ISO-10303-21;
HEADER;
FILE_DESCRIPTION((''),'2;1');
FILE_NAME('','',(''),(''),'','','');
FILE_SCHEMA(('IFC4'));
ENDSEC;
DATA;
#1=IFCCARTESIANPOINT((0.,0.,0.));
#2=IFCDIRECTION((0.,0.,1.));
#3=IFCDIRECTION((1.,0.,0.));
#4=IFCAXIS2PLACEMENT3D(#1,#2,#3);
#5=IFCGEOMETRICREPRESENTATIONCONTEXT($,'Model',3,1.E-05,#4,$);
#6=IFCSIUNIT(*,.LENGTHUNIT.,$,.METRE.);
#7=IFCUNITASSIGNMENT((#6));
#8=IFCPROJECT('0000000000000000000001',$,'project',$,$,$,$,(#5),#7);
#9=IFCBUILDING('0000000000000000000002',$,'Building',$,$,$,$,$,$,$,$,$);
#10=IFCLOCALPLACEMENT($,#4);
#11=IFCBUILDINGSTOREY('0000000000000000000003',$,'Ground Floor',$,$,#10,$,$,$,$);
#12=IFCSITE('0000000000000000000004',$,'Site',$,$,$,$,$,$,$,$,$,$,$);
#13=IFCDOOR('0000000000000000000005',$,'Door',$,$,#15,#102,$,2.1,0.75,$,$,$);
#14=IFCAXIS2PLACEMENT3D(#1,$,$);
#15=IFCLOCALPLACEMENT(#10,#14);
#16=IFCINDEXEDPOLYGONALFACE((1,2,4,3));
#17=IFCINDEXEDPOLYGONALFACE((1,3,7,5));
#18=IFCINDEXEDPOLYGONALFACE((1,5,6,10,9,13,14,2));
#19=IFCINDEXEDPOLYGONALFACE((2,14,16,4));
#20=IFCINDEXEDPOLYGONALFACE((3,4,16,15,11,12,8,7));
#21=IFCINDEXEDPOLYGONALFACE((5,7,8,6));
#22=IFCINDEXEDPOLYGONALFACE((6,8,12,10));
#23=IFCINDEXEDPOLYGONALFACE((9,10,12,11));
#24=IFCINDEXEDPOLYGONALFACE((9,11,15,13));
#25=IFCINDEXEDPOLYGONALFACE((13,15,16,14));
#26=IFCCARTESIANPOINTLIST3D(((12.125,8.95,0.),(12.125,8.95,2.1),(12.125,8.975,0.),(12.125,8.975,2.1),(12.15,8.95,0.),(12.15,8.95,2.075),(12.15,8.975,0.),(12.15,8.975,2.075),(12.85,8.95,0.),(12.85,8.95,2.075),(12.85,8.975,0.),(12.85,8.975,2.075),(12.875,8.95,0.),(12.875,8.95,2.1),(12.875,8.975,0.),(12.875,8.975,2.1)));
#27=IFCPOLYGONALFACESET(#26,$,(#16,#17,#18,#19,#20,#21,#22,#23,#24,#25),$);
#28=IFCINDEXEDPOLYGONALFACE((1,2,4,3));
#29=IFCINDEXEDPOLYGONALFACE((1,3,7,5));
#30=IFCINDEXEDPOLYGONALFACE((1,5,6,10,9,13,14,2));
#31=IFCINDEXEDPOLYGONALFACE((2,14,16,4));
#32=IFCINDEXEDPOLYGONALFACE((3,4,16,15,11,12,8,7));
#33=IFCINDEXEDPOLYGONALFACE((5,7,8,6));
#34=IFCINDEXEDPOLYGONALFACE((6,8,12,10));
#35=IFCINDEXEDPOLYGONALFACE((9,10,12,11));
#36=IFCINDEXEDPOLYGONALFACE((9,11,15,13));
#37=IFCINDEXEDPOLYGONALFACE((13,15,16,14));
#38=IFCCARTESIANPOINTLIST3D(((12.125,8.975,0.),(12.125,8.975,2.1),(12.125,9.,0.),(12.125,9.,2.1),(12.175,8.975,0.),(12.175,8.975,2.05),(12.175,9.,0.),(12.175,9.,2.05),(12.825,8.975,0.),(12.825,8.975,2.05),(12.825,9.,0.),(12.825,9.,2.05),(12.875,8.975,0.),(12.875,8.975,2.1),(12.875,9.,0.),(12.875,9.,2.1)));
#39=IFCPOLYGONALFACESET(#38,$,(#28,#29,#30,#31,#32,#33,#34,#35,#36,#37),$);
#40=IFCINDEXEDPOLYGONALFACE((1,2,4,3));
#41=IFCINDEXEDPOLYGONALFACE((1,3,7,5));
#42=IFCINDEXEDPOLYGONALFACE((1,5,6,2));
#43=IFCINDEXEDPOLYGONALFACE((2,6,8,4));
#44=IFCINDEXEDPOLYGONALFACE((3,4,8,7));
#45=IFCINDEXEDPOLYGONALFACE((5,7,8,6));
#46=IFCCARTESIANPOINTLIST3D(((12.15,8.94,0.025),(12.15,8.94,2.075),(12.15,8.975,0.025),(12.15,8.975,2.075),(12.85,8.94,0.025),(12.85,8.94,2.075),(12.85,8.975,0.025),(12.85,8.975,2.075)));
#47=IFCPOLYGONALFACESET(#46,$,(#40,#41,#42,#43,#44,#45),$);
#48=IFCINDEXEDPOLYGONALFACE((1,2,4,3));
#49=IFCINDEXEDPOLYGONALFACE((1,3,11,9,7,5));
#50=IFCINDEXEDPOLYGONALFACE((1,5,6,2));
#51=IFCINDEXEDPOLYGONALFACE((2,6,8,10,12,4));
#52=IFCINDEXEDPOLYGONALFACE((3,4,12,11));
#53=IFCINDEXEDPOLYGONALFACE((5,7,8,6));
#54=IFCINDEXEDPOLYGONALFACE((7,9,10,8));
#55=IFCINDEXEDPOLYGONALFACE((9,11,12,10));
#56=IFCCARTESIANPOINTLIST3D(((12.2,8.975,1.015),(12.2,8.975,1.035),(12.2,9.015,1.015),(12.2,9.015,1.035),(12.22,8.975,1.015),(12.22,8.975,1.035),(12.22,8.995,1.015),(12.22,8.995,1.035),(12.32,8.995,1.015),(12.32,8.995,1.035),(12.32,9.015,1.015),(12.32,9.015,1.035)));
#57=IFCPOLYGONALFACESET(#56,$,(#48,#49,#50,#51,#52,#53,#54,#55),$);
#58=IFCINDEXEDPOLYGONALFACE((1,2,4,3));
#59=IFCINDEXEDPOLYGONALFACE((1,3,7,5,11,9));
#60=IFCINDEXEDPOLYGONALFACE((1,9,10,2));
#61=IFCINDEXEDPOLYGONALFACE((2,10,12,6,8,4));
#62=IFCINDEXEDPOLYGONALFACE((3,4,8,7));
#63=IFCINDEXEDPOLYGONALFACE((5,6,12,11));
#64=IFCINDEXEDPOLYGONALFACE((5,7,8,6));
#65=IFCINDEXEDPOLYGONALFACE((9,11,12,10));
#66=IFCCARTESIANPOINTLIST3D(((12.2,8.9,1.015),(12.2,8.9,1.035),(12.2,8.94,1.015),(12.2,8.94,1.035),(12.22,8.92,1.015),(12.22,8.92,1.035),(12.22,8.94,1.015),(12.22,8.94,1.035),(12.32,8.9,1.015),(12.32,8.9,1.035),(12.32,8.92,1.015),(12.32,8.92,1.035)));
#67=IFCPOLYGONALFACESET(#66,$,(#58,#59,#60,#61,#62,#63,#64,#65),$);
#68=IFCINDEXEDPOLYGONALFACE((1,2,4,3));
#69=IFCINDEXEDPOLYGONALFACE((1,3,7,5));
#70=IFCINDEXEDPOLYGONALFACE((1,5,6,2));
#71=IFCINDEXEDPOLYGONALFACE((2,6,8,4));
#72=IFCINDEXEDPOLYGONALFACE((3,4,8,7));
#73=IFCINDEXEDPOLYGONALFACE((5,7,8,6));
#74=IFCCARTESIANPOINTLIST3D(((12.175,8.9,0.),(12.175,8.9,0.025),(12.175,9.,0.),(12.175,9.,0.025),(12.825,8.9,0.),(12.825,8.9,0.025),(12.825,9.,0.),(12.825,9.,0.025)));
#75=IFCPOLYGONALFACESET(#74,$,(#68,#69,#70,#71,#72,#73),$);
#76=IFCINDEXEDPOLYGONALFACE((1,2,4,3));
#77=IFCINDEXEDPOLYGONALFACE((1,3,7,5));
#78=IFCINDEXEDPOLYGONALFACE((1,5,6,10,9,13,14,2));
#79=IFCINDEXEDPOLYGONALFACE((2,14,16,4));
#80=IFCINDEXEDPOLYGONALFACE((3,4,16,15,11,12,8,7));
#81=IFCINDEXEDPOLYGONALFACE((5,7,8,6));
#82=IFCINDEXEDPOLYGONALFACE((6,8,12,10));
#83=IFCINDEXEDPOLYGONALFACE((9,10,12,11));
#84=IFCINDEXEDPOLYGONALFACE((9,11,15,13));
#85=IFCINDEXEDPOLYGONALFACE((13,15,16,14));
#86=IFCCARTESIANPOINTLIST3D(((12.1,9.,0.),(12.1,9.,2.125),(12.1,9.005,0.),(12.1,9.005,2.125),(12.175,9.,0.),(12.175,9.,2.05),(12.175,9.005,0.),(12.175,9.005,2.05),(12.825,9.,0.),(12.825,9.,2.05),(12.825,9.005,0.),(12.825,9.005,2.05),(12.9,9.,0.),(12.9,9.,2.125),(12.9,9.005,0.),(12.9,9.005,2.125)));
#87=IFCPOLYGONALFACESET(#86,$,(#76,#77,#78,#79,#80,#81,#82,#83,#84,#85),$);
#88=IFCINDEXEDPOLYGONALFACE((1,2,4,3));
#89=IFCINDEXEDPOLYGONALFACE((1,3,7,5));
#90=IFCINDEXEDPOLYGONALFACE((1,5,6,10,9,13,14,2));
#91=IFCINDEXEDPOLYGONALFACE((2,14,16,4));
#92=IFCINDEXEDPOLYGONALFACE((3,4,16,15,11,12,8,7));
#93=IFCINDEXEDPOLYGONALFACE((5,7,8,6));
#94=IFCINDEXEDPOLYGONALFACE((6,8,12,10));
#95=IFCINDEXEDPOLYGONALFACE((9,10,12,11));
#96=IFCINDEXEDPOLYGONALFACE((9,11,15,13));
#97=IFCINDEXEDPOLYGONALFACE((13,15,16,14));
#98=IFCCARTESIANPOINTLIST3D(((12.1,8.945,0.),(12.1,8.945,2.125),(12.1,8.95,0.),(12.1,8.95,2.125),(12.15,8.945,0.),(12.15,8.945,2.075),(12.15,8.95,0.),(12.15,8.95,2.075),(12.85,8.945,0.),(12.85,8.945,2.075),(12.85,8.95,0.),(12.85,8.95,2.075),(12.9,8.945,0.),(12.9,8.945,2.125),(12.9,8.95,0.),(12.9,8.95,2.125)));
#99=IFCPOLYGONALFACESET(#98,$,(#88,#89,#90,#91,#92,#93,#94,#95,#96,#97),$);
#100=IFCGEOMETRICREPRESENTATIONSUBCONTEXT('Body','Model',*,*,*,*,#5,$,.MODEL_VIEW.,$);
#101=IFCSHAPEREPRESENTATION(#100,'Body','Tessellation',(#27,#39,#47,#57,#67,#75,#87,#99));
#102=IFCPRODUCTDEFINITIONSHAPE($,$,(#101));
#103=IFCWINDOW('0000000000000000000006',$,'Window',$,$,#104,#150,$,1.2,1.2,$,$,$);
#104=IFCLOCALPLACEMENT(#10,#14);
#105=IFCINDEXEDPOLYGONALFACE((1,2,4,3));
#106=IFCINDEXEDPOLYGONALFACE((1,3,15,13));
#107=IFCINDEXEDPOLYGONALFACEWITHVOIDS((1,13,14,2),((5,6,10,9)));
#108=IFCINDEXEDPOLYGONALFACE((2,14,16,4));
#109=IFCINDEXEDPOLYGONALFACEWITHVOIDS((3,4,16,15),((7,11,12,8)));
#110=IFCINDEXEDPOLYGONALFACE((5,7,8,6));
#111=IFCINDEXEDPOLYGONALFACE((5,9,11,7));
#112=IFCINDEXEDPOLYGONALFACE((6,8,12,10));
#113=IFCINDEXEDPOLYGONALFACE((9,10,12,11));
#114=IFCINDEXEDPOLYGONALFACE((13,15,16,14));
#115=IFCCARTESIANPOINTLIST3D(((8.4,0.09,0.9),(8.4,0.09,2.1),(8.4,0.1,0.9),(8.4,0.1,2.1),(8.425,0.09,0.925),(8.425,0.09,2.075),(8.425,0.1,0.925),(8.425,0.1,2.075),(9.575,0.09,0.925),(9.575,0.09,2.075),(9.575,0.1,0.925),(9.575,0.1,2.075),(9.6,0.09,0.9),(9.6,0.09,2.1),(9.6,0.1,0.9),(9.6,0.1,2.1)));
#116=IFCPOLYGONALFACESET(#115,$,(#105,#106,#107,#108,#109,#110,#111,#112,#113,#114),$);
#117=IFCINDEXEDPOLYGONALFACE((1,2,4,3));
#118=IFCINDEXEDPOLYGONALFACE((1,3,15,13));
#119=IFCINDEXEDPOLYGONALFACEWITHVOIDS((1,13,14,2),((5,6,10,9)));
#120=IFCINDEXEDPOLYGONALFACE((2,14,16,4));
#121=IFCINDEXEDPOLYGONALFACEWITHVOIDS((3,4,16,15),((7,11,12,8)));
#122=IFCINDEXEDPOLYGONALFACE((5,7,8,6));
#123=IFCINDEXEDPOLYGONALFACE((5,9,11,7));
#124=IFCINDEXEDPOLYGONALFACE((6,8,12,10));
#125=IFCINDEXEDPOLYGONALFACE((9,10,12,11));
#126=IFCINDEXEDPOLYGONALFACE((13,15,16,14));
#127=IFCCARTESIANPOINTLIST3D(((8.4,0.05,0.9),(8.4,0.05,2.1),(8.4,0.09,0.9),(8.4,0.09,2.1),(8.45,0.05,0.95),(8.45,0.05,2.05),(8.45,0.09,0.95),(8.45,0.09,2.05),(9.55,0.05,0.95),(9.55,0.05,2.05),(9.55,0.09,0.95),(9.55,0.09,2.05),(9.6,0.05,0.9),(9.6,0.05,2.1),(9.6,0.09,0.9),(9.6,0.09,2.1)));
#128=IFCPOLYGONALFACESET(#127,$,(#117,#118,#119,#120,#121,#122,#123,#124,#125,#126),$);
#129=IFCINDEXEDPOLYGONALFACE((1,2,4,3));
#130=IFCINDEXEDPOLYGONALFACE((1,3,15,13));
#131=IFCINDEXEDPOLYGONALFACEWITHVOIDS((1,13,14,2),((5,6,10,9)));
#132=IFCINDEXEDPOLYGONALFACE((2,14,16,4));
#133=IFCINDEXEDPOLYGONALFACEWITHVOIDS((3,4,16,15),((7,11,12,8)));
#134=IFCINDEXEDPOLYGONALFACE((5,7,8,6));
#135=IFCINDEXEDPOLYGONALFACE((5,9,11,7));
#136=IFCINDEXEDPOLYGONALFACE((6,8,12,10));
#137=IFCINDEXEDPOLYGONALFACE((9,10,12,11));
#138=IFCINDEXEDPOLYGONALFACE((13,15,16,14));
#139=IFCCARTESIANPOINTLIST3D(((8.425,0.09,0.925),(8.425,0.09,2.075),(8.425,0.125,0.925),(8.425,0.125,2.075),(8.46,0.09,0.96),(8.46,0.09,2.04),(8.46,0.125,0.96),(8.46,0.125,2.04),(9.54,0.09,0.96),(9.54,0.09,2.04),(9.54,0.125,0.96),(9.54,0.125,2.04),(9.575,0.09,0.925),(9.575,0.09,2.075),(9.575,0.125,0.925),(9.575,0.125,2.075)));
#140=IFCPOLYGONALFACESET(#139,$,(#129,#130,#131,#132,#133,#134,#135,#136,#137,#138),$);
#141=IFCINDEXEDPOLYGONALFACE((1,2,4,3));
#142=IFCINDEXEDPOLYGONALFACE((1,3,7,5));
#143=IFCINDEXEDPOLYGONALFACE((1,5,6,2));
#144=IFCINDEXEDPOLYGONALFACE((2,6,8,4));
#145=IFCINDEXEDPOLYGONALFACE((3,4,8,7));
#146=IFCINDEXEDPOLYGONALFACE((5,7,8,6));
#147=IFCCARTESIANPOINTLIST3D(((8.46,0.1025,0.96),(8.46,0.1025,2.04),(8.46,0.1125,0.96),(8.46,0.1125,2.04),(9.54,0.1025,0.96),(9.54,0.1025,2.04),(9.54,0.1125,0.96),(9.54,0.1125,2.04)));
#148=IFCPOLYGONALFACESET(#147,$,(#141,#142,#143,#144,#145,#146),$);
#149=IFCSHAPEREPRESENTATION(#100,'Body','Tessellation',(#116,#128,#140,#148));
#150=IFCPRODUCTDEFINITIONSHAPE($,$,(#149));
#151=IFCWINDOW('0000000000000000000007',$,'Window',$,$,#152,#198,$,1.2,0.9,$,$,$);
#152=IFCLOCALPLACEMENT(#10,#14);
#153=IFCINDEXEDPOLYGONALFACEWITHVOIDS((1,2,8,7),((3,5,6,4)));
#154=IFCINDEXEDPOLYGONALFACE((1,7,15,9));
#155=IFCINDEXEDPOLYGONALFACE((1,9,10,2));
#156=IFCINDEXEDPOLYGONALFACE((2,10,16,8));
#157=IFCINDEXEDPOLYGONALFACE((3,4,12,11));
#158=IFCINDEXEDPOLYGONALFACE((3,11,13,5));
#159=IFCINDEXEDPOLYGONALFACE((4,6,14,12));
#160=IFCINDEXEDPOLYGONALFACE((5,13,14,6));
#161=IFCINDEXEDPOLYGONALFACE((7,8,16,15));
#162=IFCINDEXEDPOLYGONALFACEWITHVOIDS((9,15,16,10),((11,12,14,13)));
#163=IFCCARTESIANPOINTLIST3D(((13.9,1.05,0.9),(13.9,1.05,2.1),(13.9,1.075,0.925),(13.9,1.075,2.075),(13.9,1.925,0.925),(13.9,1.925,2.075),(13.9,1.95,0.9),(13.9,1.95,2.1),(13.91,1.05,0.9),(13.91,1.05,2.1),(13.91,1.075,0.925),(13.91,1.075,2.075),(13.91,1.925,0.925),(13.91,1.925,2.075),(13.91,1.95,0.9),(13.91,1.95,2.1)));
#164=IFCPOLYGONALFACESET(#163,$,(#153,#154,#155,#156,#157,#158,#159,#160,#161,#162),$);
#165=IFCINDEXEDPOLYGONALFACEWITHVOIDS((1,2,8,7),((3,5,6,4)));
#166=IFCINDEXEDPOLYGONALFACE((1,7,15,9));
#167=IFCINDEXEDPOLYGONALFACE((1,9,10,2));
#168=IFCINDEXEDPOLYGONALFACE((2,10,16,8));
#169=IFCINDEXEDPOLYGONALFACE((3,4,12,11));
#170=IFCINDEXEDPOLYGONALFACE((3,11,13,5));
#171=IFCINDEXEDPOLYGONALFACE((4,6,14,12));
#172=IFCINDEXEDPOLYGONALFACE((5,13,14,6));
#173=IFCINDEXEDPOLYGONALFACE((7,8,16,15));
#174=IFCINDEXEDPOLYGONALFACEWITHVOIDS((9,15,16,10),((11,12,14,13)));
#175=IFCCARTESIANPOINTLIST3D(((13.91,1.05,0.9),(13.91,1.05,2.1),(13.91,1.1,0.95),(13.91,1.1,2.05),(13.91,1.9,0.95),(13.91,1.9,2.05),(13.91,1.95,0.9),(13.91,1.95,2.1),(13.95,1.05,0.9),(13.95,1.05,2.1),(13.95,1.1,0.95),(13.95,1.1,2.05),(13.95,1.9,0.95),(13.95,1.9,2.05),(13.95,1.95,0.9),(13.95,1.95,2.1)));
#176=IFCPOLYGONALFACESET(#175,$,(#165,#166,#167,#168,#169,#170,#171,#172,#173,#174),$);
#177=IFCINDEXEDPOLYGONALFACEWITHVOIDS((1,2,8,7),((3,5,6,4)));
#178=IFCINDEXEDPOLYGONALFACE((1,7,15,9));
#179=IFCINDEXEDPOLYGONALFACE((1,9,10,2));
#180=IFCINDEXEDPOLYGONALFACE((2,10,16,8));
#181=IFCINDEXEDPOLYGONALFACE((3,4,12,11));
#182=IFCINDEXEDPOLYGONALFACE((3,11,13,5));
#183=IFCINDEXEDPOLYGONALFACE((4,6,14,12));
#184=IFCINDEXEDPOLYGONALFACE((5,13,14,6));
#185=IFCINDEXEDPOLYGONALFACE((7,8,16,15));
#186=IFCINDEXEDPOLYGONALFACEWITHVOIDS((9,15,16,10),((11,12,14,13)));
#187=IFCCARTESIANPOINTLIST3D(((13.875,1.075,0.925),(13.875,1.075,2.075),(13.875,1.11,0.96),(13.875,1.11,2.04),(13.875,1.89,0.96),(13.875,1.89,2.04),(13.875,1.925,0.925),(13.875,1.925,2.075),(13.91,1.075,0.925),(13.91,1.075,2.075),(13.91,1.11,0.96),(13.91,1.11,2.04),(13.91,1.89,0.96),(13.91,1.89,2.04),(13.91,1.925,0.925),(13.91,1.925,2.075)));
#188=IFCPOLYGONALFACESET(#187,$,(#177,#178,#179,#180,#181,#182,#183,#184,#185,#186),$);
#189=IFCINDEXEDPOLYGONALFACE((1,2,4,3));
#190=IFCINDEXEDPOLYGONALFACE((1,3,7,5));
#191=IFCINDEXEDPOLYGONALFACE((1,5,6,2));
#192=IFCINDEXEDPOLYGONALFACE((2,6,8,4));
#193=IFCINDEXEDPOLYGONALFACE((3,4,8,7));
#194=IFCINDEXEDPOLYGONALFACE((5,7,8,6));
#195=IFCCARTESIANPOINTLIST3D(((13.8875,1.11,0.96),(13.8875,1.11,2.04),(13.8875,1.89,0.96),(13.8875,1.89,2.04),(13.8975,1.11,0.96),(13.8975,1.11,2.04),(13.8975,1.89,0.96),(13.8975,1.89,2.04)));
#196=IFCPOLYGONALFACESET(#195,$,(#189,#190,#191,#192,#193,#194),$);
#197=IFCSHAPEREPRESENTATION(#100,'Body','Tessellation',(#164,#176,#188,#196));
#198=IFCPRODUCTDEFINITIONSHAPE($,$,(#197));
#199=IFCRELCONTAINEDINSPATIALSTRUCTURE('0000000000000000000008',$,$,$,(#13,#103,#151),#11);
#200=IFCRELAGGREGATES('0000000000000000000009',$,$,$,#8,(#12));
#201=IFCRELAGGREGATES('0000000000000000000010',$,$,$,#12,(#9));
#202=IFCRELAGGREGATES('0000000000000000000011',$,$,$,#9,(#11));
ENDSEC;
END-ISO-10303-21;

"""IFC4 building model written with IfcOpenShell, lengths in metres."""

from ifc_helpers import new_model, si_unit, frame, origin_with_axes, place, context, subcontext, project, spatial, line, indexed_curve, outline, extrude, element, save


model = new_model("IFC4")

# Units and contexts
model_context = context("Model", 3, precision=1e-05, world=origin_with_axes())
body_context = subcontext(model_context, "Body", "Model", "MODEL_VIEW")
ifc_project = project(units=[si_unit("LENGTHUNIT", "METRE")], contexts=[model_context])

# Site, building, storey
site = spatial("IfcSite", under=ifc_project, Name="Site")
building = spatial("IfcBuilding", under=site, Name="Building")
storey_placement = place(None, origin_with_axes())
storey = spatial("IfcBuildingStorey", under=building, at=storey_placement, Name="Ground Floor")

# Door
door_1_placement = place(storey_placement, frame((12.875, 9.0, 0.0), z_axis=(0.0, 0.0, 1.0), x_axis=(-1.0, 0.0, 0.0)))
element("IfcDoor", 1, at=door_1_placement, inside=storey, Name="Door", OverallHeight=2.1, OverallWidth=0.75, context=body_context, shape_type="SweptSolid", body=[
    extrude(outline(indexed_curve([(0.0, 0.0), (0.0, 2.1), (0.75, 2.1), (0.75, 0.0), (0.725, 0.0), (0.725, 2.075), (0.025, 2.075), (0.025, 0.0)], segments=[line(1, 2, 3, 4, 5, 6, 7, 8, 1)])), frame((0.0, 0.025, 0.0), z_axis=(0.0, -1.0, 0.0), x_axis=(1.0, 0.0, 0.0)), (0.0, 0.0, -1.0), 0.025),
    extrude(outline(indexed_curve([(0.0, 0.0), (0.0, 2.1), (0.75, 2.1), (0.75, 0.0), (0.7, 0.0), (0.7, 2.05), (0.05, 2.05), (0.05, 0.0)], segments=[line(1, 2, 3, 4, 5, 6, 7, 8, 1)])), frame((0.0, 0.0, 0.0), z_axis=(0.0, -1.0, 0.0), x_axis=(1.0, 0.0, 0.0)), (0.0, 0.0, -1.0), 0.025),
    extrude(outline(indexed_curve([(0.0, 0.0), (0.7, 0.0), (0.7, 0.035), (0.0, 0.035)], segments=[line(1, 2, 3, 4, 1)])), frame((0.025, 0.025, 0.025), z_axis=(0.0, 0.0, 1.0), x_axis=(1.0, 0.0, 0.0)), (0.0, 0.0, 1.0), 2.05),
    extrude(outline(indexed_curve([(0.0, 0.0), (0.0, -0.04), (-0.12, -0.04), (-0.12, -0.02), (-0.02, -0.02), (-0.02, 0.0)], segments=[line(1, 2, 3, 4, 5, 6, 1)])), frame((0.675, 0.025, 1.015), z_axis=(0.0, 0.0, 1.0), x_axis=(1.0, 0.0, 0.0)), (0.0, 0.0, 1.0), 0.02),
    extrude(outline(indexed_curve([(0.0, 0.0), (0.0, 0.04), (-0.12, 0.04), (-0.12, 0.02), (-0.02, 0.02), (-0.02, 0.0)], segments=[line(1, 2, 3, 4, 5, 6, 1)])), frame((0.675, 0.06, 1.015), z_axis=(0.0, 0.0, 1.0), x_axis=(1.0, 0.0, 0.0)), (0.0, 0.0, 1.0), 0.02),
    extrude(outline(indexed_curve([(0.0, 0.0), (0.65, 0.0), (0.65, 0.1), (0.0, 0.1)], segments=[line(1, 2, 3, 4, 1)])), frame((0.05, 0.0, 0.0), z_axis=(0.0, 0.0, 1.0), x_axis=(1.0, 0.0, 0.0)), (0.0, 0.0, 1.0), 0.025),
    extrude(outline(indexed_curve([(0.0, 0.0), (0.0, 2.125), (0.8, 2.125), (0.8, 0.0), (0.725, 0.0), (0.725, 2.05), (0.075, 2.05), (0.075, 0.0)], segments=[line(1, 2, 3, 4, 5, 6, 7, 8, 1)])), frame((-0.025, -0.005, 0.0), z_axis=(0.0, -1.0, 0.0), x_axis=(1.0, 0.0, 0.0)), (0.0, 0.0, -1.0), 0.005),
    extrude(outline(indexed_curve([(0.0, 0.0), (0.0, 2.125), (0.8, 2.125), (0.8, 0.0), (0.75, 0.0), (0.75, 2.075), (0.05, 2.075), (0.05, 0.0)], segments=[line(1, 2, 3, 4, 5, 6, 7, 8, 1)])), frame((-0.025, 0.05, 0.0), z_axis=(0.0, -1.0, 0.0), x_axis=(1.0, 0.0, 0.0)), (0.0, 0.0, -1.0), 0.005),
])

# Windows
window_1_placement = place(storey_placement, frame((8.4, 0.0, 0.9), z_axis=(0.0, 0.0, 1.0), x_axis=(1.0, 0.0, 0.0)))
element("IfcWindow", 2, at=window_1_placement, inside=storey, Name="Window", OverallHeight=1.2, OverallWidth=1.2, context=body_context, shape_type="SweptSolid", body=[
    extrude(outline(indexed_curve([(0.0, 0.0), (1.2, 0.0), (1.2, 1.2), (0.0, 1.2)], segments=[line(1, 2, 3, 4, 1)]), holes=[indexed_curve([(0.025, 0.025), (1.175, 0.025), (1.175, 1.175), (0.025, 1.175)], segments=[line(1, 2, 3, 4, 1)])]), frame((0.0, 0.09, 0.0), z_axis=(0.0, -1.0, 0.0), x_axis=(1.0, 0.0, 0.0)), (0.0, 0.0, -1.0), 0.01),
    extrude(outline(indexed_curve([(0.0, 0.0), (1.2, 0.0), (1.2, 1.2), (0.0, 1.2)], segments=[line(1, 2, 3, 4, 1)]), holes=[indexed_curve([(0.05, 0.05), (1.15, 0.05), (1.15, 1.15), (0.05, 1.15)], segments=[line(1, 2, 3, 4, 1)])]), frame((0.0, 0.05, 0.0), z_axis=(0.0, -1.0, 0.0), x_axis=(1.0, 0.0, 0.0)), (0.0, 0.0, -1.0), 0.04),
    extrude(outline(indexed_curve([(0.0, 0.0), (1.15, 0.0), (1.15, 1.15), (0.0, 1.15)], segments=[line(1, 2, 3, 4, 1)]), holes=[indexed_curve([(0.035, 0.035), (1.115, 0.035), (1.115, 1.115), (0.035, 1.115)], segments=[line(1, 2, 3, 4, 1)])]), frame((0.025, 0.09, 0.025), z_axis=(0.0, -1.0, 0.0), x_axis=(1.0, 0.0, 0.0)), (0.0, 0.0, -1.0), 0.035),
    extrude(outline(indexed_curve([(0.035, 0.035), (1.115, 0.035), (1.115, 1.115), (0.035, 1.115)], segments=[line(1, 2, 3, 4, 1)])), frame((0.025, 0.1025, 0.025), z_axis=(0.0, -1.0, 0.0), x_axis=(1.0, 0.0, 0.0)), (0.0, 0.0, -1.0), 0.01),
])
window_2_placement = place(storey_placement, frame((14.0, 1.05, 0.9), z_axis=(0.0, 0.0, 1.0), x_axis=(0.0, 1.0, 0.0)))
element("IfcWindow", 3, at=window_2_placement, inside=storey, Name="Window", OverallHeight=1.2, OverallWidth=0.9, context=body_context, shape_type="SweptSolid", body=[
    extrude(outline(indexed_curve([(0.0, 0.0), (0.9, 0.0), (0.9, 1.2), (0.0, 1.2)], segments=[line(1, 2, 3, 4, 1)]), holes=[indexed_curve([(0.025, 0.025), (0.875, 0.025), (0.875, 1.175), (0.025, 1.175)], segments=[line(1, 2, 3, 4, 1)])]), frame((0.0, 0.09, 0.0), z_axis=(0.0, -1.0, 0.0), x_axis=(1.0, 0.0, 0.0)), (0.0, 0.0, -1.0), 0.01),
    extrude(outline(indexed_curve([(0.0, 0.0), (0.9, 0.0), (0.9, 1.2), (0.0, 1.2)], segments=[line(1, 2, 3, 4, 1)]), holes=[indexed_curve([(0.05, 0.05), (0.85, 0.05), (0.85, 1.15), (0.05, 1.15)], segments=[line(1, 2, 3, 4, 1)])]), frame((0.0, 0.05, 0.0), z_axis=(0.0, -1.0, 0.0), x_axis=(1.0, 0.0, 0.0)), (0.0, 0.0, -1.0), 0.04),
    extrude(outline(indexed_curve([(0.0, 0.0), (0.85, 0.0), (0.85, 1.15), (0.0, 1.15)], segments=[line(1, 2, 3, 4, 1)]), holes=[indexed_curve([(0.035, 0.035), (0.815, 0.035), (0.815, 1.115), (0.035, 1.115)], segments=[line(1, 2, 3, 4, 1)])]), frame((0.025, 0.09, 0.025), z_axis=(0.0, -1.0, 0.0), x_axis=(1.0, 0.0, 0.0)), (0.0, 0.0, -1.0), 0.035),
    extrude(outline(indexed_curve([(0.035, 0.035), (0.815, 0.035), (0.815, 1.115), (0.035, 1.115)], segments=[line(1, 2, 3, 4, 1)])), frame((0.025, 0.1025, 0.025), z_axis=(0.0, -1.0, 0.0), x_axis=(1.0, 0.0, 0.0)), (0.0, 0.0, -1.0), 0.01),
])

save(model, "model.ifc")
